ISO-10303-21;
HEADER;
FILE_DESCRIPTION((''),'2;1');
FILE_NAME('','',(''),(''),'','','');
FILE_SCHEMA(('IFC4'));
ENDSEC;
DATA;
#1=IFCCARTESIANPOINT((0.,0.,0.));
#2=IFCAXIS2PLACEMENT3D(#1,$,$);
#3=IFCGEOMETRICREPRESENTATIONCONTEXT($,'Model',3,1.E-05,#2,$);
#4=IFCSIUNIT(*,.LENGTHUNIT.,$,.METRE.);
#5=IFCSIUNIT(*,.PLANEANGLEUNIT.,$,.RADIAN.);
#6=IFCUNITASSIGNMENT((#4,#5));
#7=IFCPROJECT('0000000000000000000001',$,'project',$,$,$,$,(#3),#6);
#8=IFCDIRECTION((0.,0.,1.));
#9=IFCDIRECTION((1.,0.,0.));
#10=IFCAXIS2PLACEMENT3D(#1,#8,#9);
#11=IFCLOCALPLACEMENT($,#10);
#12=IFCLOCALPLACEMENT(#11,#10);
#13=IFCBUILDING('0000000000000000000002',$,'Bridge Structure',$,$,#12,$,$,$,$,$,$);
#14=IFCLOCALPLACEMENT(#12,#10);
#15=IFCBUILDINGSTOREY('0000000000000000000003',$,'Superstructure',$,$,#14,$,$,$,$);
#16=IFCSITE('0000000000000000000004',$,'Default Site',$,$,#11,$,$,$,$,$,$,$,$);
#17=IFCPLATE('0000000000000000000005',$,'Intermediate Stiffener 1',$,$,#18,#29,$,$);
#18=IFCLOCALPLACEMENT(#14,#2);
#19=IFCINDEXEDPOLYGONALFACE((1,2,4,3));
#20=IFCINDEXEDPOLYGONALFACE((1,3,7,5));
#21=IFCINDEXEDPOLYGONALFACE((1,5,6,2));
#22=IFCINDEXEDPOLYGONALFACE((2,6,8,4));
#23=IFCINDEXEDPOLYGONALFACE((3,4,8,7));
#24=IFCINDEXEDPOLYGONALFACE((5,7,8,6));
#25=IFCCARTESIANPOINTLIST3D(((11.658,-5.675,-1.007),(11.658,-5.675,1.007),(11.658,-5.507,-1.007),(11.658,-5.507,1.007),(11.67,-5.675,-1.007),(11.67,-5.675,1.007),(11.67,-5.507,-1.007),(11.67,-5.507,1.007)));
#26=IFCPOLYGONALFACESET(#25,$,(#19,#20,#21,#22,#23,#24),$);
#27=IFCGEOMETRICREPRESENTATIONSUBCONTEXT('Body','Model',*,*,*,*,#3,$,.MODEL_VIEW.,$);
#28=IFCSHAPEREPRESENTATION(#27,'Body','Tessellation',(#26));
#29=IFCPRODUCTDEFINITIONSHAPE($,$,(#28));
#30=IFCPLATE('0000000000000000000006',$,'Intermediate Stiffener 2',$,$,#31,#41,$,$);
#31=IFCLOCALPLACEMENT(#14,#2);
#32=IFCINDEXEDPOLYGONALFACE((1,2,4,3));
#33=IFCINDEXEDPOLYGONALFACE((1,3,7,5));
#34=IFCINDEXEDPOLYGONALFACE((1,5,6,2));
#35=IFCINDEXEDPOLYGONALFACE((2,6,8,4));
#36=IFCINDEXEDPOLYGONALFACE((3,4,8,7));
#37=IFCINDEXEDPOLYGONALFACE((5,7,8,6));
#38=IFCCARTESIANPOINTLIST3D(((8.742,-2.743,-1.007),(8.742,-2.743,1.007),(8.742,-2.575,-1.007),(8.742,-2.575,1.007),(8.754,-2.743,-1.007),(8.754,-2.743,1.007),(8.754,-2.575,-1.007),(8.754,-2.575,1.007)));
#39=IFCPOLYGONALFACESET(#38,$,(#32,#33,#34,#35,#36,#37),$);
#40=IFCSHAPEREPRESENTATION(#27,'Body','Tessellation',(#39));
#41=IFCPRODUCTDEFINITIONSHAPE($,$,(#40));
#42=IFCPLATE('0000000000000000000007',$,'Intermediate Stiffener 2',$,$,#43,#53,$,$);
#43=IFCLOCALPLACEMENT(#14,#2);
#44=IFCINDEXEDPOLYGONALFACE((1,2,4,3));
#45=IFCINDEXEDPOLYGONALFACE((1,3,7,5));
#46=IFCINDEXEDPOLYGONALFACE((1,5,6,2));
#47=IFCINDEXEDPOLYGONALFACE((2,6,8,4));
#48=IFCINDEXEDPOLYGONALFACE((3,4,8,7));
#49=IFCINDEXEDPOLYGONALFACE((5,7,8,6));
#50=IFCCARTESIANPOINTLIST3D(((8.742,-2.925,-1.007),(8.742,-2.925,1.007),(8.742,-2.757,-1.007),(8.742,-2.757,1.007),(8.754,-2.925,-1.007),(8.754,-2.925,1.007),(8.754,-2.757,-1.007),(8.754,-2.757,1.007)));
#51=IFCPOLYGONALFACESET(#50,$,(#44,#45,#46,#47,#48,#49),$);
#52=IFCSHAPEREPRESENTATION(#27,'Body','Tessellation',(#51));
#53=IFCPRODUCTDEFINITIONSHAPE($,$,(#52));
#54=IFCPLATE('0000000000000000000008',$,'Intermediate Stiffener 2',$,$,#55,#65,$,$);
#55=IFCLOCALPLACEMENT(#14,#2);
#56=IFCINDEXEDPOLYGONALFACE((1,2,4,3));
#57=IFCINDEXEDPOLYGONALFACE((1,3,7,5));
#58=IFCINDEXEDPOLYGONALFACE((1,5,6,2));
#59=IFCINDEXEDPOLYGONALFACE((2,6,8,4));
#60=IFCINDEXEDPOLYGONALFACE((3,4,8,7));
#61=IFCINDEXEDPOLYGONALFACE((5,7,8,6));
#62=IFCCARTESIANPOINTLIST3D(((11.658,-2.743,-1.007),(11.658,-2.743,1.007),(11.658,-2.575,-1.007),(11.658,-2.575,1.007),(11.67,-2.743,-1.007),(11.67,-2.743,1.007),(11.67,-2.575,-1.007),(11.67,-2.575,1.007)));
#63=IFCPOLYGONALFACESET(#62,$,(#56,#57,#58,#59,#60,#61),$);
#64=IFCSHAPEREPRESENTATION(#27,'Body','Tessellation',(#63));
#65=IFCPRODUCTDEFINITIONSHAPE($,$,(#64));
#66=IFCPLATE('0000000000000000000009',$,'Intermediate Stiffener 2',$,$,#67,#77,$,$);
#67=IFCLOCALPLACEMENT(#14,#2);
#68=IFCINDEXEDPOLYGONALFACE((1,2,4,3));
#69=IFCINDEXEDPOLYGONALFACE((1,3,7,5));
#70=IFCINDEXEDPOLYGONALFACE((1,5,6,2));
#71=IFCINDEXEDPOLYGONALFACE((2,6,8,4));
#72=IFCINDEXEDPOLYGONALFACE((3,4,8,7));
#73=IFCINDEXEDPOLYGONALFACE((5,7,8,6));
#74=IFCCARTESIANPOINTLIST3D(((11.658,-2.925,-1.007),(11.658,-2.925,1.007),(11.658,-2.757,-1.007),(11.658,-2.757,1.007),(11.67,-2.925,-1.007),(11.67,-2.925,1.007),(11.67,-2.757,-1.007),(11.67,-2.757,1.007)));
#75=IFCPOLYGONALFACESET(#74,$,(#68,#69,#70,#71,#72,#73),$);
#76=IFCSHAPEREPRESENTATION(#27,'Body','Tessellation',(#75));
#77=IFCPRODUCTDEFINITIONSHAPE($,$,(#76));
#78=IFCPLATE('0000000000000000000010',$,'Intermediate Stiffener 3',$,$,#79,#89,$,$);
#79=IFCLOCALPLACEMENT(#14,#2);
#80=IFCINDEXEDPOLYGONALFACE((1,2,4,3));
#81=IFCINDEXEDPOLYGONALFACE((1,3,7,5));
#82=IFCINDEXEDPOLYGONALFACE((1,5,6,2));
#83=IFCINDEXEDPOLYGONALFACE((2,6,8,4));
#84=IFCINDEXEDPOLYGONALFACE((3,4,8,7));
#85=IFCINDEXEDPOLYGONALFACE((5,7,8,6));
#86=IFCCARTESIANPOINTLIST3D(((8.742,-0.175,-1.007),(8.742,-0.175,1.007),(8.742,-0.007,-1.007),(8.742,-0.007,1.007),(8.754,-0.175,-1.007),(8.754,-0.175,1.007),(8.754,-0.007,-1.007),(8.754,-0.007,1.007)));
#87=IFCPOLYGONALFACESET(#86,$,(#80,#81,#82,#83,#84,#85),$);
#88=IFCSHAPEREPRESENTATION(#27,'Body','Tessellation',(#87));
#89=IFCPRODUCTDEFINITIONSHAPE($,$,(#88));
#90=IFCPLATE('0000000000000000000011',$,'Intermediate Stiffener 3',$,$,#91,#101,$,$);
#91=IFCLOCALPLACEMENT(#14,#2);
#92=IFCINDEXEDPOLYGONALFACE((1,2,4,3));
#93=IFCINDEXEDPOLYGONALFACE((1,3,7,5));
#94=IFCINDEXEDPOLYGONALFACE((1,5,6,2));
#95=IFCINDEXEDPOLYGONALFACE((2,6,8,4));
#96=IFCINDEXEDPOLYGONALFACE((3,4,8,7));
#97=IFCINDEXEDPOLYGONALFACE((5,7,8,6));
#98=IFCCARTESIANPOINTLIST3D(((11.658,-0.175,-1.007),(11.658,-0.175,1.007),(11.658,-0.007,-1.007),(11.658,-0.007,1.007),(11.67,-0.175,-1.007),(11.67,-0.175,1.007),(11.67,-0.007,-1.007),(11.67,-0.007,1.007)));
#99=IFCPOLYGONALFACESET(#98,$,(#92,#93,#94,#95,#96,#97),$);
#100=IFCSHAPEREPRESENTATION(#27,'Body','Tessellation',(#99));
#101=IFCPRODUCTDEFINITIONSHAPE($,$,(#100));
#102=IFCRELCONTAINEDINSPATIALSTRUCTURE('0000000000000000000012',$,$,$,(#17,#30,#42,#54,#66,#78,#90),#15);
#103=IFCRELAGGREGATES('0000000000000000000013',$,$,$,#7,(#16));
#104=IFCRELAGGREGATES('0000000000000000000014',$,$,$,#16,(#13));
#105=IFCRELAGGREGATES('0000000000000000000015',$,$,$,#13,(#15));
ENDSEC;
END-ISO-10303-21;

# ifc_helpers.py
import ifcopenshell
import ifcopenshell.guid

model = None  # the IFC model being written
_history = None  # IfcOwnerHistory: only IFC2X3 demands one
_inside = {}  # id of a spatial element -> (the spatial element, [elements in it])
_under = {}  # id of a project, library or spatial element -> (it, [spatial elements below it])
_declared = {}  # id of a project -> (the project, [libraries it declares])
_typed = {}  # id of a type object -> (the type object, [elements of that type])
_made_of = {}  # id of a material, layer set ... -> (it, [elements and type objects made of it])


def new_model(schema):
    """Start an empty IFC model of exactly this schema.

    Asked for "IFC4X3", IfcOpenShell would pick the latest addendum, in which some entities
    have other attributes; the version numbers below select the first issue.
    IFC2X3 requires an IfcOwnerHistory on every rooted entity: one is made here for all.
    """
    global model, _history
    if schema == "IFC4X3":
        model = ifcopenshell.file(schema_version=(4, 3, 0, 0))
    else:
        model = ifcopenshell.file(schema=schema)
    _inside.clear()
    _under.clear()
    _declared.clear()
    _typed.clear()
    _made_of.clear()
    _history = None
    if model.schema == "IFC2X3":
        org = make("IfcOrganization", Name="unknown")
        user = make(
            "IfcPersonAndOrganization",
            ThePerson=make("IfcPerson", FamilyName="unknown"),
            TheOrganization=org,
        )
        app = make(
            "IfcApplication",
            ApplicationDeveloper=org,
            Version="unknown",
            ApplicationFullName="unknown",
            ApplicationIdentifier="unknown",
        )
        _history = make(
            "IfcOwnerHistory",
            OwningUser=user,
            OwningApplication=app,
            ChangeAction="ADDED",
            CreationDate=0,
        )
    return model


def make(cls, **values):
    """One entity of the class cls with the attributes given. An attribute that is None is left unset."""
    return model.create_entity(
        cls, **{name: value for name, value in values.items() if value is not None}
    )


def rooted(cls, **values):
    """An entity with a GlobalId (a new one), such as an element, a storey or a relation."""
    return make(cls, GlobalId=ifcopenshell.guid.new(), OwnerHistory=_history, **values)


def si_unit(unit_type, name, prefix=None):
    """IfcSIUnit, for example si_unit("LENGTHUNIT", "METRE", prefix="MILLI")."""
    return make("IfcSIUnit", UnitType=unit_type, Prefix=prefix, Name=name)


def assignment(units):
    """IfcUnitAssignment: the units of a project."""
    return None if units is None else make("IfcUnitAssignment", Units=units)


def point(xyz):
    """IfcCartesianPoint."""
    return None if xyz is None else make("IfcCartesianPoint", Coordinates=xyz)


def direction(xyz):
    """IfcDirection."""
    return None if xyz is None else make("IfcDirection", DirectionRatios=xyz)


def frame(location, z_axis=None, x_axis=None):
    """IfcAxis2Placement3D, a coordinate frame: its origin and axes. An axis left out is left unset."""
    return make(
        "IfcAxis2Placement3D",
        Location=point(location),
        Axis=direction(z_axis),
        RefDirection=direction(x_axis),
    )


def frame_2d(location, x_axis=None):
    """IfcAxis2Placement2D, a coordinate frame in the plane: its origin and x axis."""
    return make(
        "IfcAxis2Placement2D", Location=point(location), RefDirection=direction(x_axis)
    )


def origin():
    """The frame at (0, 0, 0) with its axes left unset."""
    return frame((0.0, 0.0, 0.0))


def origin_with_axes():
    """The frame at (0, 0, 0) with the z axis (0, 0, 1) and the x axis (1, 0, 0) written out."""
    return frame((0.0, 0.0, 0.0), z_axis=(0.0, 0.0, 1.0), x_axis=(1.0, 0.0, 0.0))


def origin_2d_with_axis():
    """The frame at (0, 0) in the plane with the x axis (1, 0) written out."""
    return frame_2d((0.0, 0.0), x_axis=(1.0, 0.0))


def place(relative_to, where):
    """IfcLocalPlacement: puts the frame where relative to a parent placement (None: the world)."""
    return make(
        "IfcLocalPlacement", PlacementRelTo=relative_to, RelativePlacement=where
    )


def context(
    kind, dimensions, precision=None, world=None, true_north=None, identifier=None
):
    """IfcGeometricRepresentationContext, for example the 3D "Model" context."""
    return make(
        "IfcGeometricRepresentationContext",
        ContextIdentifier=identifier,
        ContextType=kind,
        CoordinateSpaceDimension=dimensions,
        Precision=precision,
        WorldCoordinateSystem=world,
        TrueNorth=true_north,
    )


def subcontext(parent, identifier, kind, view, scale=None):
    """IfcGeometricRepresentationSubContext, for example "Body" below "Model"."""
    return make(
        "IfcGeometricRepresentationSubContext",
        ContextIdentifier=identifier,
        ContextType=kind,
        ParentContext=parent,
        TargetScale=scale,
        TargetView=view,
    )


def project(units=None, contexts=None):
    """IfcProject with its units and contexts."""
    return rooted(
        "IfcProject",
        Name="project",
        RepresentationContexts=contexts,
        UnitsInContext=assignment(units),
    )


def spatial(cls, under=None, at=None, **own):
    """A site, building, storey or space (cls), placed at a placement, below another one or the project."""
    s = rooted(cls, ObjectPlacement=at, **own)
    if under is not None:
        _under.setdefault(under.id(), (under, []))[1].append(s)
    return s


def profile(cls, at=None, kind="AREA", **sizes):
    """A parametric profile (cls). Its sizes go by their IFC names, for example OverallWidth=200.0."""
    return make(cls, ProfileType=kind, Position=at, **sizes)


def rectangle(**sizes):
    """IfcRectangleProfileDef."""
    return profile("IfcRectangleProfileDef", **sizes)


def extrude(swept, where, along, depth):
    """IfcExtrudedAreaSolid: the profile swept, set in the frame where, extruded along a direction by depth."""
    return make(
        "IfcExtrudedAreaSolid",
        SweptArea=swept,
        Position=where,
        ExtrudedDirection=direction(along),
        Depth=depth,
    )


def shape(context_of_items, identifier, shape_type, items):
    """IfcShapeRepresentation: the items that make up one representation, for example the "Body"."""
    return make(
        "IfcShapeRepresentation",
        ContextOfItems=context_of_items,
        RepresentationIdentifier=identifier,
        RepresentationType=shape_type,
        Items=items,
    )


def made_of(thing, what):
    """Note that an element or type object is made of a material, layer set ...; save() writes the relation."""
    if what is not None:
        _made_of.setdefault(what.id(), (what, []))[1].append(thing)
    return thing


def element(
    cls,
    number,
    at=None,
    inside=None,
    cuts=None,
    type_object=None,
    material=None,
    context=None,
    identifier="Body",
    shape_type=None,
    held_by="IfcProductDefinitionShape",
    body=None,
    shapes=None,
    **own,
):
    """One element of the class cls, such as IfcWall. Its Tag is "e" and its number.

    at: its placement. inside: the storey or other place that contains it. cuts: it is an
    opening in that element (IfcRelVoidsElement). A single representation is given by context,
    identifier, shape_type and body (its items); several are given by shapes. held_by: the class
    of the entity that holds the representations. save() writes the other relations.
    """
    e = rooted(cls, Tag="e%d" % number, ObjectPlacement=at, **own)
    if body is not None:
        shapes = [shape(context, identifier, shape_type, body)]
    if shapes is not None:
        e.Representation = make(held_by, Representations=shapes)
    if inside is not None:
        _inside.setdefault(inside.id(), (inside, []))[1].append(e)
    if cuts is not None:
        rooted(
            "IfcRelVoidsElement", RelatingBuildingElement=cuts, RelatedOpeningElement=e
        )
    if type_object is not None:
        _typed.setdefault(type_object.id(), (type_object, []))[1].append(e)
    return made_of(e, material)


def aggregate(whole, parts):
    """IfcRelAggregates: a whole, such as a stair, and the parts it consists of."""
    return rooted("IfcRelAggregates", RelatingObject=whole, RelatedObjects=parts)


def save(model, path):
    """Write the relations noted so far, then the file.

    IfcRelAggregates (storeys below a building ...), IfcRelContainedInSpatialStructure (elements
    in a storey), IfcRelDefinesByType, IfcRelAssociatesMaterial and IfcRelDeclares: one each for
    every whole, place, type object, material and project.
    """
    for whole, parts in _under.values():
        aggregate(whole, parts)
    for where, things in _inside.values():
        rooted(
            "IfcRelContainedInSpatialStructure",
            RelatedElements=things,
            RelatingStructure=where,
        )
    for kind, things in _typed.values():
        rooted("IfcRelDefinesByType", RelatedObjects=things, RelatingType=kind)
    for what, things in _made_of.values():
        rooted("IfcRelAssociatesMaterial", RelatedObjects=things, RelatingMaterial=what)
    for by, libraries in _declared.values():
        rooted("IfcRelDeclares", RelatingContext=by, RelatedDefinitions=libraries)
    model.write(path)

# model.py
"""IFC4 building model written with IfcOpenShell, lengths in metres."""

from ifc_helpers import new_model, si_unit, frame, origin, origin_with_axes, origin_2d_with_axis, place, context, subcontext, project, spatial, rectangle, extrude, element, save


model = new_model("IFC4")

# Units and contexts
model_context = context("Model", 3, precision=1e-05, world=origin())
body_context = subcontext(model_context, "Body", "Model", "MODEL_VIEW")
ifc_project = project(units=[si_unit("LENGTHUNIT", "METRE"), si_unit("PLANEANGLEUNIT", "RADIAN")], contexts=[model_context])

# Site, building, storey
site_placement = place(None, origin_with_axes())
site = spatial("IfcSite", under=ifc_project, at=site_placement, Name="Default Site")
building_placement = place(site_placement, origin_with_axes())
building = spatial("IfcBuilding", under=site, at=building_placement, Name="Bridge Structure")
storey_placement = place(building_placement, origin_with_axes())
storey = spatial("IfcBuildingStorey", under=building, at=storey_placement, Name="Superstructure")

# Plates
for number, where, z_axis, x_axis, name in (
    (1, (11.664, -5.591, -1.007), (0.0, 0.0, 1.0), (1.0, 0.0, 0.0), "Intermediate Stiffener 1"),
    (2, (8.748, -2.659, -1.007), (0.0, 0.0, 1.0), (1.0, 0.0, 0.0), "Intermediate Stiffener 2"),
    (3, (8.748, -2.841, -1.007), (0.0, 0.0, 1.0), (1.0, 0.0, 0.0), "Intermediate Stiffener 2"),
    (4, (11.664, -2.659, -1.007), (0.0, 0.0, 1.0), (1.0, 0.0, 0.0), "Intermediate Stiffener 2"),
    (5, (11.664, -2.841, -1.007), (0.0, 0.0, 1.0), (1.0, 0.0, 0.0), "Intermediate Stiffener 2"),
    (6, (8.748, -0.091, -1.007), (0.0, 0.0, 1.0), (1.0, 0.0, 0.0), "Intermediate Stiffener 3"),
    (7, (11.664, -0.091, -1.007), (0.0, 0.0, 1.0), (1.0, 0.0, 0.0), "Intermediate Stiffener 3"),
):
    element("IfcPlate", number, at=place(storey_placement, frame(where, z_axis=z_axis, x_axis=x_axis)), inside=storey, Name=name, context=body_context, shape_type="SweptSolid", body=[
        extrude(rectangle(XDim=0.012, YDim=0.168, at=origin_2d_with_axis()), origin_with_axes(), (0.0, 0.0, 1.0), 2.014),
    ])

save(model, "model.ifc")
